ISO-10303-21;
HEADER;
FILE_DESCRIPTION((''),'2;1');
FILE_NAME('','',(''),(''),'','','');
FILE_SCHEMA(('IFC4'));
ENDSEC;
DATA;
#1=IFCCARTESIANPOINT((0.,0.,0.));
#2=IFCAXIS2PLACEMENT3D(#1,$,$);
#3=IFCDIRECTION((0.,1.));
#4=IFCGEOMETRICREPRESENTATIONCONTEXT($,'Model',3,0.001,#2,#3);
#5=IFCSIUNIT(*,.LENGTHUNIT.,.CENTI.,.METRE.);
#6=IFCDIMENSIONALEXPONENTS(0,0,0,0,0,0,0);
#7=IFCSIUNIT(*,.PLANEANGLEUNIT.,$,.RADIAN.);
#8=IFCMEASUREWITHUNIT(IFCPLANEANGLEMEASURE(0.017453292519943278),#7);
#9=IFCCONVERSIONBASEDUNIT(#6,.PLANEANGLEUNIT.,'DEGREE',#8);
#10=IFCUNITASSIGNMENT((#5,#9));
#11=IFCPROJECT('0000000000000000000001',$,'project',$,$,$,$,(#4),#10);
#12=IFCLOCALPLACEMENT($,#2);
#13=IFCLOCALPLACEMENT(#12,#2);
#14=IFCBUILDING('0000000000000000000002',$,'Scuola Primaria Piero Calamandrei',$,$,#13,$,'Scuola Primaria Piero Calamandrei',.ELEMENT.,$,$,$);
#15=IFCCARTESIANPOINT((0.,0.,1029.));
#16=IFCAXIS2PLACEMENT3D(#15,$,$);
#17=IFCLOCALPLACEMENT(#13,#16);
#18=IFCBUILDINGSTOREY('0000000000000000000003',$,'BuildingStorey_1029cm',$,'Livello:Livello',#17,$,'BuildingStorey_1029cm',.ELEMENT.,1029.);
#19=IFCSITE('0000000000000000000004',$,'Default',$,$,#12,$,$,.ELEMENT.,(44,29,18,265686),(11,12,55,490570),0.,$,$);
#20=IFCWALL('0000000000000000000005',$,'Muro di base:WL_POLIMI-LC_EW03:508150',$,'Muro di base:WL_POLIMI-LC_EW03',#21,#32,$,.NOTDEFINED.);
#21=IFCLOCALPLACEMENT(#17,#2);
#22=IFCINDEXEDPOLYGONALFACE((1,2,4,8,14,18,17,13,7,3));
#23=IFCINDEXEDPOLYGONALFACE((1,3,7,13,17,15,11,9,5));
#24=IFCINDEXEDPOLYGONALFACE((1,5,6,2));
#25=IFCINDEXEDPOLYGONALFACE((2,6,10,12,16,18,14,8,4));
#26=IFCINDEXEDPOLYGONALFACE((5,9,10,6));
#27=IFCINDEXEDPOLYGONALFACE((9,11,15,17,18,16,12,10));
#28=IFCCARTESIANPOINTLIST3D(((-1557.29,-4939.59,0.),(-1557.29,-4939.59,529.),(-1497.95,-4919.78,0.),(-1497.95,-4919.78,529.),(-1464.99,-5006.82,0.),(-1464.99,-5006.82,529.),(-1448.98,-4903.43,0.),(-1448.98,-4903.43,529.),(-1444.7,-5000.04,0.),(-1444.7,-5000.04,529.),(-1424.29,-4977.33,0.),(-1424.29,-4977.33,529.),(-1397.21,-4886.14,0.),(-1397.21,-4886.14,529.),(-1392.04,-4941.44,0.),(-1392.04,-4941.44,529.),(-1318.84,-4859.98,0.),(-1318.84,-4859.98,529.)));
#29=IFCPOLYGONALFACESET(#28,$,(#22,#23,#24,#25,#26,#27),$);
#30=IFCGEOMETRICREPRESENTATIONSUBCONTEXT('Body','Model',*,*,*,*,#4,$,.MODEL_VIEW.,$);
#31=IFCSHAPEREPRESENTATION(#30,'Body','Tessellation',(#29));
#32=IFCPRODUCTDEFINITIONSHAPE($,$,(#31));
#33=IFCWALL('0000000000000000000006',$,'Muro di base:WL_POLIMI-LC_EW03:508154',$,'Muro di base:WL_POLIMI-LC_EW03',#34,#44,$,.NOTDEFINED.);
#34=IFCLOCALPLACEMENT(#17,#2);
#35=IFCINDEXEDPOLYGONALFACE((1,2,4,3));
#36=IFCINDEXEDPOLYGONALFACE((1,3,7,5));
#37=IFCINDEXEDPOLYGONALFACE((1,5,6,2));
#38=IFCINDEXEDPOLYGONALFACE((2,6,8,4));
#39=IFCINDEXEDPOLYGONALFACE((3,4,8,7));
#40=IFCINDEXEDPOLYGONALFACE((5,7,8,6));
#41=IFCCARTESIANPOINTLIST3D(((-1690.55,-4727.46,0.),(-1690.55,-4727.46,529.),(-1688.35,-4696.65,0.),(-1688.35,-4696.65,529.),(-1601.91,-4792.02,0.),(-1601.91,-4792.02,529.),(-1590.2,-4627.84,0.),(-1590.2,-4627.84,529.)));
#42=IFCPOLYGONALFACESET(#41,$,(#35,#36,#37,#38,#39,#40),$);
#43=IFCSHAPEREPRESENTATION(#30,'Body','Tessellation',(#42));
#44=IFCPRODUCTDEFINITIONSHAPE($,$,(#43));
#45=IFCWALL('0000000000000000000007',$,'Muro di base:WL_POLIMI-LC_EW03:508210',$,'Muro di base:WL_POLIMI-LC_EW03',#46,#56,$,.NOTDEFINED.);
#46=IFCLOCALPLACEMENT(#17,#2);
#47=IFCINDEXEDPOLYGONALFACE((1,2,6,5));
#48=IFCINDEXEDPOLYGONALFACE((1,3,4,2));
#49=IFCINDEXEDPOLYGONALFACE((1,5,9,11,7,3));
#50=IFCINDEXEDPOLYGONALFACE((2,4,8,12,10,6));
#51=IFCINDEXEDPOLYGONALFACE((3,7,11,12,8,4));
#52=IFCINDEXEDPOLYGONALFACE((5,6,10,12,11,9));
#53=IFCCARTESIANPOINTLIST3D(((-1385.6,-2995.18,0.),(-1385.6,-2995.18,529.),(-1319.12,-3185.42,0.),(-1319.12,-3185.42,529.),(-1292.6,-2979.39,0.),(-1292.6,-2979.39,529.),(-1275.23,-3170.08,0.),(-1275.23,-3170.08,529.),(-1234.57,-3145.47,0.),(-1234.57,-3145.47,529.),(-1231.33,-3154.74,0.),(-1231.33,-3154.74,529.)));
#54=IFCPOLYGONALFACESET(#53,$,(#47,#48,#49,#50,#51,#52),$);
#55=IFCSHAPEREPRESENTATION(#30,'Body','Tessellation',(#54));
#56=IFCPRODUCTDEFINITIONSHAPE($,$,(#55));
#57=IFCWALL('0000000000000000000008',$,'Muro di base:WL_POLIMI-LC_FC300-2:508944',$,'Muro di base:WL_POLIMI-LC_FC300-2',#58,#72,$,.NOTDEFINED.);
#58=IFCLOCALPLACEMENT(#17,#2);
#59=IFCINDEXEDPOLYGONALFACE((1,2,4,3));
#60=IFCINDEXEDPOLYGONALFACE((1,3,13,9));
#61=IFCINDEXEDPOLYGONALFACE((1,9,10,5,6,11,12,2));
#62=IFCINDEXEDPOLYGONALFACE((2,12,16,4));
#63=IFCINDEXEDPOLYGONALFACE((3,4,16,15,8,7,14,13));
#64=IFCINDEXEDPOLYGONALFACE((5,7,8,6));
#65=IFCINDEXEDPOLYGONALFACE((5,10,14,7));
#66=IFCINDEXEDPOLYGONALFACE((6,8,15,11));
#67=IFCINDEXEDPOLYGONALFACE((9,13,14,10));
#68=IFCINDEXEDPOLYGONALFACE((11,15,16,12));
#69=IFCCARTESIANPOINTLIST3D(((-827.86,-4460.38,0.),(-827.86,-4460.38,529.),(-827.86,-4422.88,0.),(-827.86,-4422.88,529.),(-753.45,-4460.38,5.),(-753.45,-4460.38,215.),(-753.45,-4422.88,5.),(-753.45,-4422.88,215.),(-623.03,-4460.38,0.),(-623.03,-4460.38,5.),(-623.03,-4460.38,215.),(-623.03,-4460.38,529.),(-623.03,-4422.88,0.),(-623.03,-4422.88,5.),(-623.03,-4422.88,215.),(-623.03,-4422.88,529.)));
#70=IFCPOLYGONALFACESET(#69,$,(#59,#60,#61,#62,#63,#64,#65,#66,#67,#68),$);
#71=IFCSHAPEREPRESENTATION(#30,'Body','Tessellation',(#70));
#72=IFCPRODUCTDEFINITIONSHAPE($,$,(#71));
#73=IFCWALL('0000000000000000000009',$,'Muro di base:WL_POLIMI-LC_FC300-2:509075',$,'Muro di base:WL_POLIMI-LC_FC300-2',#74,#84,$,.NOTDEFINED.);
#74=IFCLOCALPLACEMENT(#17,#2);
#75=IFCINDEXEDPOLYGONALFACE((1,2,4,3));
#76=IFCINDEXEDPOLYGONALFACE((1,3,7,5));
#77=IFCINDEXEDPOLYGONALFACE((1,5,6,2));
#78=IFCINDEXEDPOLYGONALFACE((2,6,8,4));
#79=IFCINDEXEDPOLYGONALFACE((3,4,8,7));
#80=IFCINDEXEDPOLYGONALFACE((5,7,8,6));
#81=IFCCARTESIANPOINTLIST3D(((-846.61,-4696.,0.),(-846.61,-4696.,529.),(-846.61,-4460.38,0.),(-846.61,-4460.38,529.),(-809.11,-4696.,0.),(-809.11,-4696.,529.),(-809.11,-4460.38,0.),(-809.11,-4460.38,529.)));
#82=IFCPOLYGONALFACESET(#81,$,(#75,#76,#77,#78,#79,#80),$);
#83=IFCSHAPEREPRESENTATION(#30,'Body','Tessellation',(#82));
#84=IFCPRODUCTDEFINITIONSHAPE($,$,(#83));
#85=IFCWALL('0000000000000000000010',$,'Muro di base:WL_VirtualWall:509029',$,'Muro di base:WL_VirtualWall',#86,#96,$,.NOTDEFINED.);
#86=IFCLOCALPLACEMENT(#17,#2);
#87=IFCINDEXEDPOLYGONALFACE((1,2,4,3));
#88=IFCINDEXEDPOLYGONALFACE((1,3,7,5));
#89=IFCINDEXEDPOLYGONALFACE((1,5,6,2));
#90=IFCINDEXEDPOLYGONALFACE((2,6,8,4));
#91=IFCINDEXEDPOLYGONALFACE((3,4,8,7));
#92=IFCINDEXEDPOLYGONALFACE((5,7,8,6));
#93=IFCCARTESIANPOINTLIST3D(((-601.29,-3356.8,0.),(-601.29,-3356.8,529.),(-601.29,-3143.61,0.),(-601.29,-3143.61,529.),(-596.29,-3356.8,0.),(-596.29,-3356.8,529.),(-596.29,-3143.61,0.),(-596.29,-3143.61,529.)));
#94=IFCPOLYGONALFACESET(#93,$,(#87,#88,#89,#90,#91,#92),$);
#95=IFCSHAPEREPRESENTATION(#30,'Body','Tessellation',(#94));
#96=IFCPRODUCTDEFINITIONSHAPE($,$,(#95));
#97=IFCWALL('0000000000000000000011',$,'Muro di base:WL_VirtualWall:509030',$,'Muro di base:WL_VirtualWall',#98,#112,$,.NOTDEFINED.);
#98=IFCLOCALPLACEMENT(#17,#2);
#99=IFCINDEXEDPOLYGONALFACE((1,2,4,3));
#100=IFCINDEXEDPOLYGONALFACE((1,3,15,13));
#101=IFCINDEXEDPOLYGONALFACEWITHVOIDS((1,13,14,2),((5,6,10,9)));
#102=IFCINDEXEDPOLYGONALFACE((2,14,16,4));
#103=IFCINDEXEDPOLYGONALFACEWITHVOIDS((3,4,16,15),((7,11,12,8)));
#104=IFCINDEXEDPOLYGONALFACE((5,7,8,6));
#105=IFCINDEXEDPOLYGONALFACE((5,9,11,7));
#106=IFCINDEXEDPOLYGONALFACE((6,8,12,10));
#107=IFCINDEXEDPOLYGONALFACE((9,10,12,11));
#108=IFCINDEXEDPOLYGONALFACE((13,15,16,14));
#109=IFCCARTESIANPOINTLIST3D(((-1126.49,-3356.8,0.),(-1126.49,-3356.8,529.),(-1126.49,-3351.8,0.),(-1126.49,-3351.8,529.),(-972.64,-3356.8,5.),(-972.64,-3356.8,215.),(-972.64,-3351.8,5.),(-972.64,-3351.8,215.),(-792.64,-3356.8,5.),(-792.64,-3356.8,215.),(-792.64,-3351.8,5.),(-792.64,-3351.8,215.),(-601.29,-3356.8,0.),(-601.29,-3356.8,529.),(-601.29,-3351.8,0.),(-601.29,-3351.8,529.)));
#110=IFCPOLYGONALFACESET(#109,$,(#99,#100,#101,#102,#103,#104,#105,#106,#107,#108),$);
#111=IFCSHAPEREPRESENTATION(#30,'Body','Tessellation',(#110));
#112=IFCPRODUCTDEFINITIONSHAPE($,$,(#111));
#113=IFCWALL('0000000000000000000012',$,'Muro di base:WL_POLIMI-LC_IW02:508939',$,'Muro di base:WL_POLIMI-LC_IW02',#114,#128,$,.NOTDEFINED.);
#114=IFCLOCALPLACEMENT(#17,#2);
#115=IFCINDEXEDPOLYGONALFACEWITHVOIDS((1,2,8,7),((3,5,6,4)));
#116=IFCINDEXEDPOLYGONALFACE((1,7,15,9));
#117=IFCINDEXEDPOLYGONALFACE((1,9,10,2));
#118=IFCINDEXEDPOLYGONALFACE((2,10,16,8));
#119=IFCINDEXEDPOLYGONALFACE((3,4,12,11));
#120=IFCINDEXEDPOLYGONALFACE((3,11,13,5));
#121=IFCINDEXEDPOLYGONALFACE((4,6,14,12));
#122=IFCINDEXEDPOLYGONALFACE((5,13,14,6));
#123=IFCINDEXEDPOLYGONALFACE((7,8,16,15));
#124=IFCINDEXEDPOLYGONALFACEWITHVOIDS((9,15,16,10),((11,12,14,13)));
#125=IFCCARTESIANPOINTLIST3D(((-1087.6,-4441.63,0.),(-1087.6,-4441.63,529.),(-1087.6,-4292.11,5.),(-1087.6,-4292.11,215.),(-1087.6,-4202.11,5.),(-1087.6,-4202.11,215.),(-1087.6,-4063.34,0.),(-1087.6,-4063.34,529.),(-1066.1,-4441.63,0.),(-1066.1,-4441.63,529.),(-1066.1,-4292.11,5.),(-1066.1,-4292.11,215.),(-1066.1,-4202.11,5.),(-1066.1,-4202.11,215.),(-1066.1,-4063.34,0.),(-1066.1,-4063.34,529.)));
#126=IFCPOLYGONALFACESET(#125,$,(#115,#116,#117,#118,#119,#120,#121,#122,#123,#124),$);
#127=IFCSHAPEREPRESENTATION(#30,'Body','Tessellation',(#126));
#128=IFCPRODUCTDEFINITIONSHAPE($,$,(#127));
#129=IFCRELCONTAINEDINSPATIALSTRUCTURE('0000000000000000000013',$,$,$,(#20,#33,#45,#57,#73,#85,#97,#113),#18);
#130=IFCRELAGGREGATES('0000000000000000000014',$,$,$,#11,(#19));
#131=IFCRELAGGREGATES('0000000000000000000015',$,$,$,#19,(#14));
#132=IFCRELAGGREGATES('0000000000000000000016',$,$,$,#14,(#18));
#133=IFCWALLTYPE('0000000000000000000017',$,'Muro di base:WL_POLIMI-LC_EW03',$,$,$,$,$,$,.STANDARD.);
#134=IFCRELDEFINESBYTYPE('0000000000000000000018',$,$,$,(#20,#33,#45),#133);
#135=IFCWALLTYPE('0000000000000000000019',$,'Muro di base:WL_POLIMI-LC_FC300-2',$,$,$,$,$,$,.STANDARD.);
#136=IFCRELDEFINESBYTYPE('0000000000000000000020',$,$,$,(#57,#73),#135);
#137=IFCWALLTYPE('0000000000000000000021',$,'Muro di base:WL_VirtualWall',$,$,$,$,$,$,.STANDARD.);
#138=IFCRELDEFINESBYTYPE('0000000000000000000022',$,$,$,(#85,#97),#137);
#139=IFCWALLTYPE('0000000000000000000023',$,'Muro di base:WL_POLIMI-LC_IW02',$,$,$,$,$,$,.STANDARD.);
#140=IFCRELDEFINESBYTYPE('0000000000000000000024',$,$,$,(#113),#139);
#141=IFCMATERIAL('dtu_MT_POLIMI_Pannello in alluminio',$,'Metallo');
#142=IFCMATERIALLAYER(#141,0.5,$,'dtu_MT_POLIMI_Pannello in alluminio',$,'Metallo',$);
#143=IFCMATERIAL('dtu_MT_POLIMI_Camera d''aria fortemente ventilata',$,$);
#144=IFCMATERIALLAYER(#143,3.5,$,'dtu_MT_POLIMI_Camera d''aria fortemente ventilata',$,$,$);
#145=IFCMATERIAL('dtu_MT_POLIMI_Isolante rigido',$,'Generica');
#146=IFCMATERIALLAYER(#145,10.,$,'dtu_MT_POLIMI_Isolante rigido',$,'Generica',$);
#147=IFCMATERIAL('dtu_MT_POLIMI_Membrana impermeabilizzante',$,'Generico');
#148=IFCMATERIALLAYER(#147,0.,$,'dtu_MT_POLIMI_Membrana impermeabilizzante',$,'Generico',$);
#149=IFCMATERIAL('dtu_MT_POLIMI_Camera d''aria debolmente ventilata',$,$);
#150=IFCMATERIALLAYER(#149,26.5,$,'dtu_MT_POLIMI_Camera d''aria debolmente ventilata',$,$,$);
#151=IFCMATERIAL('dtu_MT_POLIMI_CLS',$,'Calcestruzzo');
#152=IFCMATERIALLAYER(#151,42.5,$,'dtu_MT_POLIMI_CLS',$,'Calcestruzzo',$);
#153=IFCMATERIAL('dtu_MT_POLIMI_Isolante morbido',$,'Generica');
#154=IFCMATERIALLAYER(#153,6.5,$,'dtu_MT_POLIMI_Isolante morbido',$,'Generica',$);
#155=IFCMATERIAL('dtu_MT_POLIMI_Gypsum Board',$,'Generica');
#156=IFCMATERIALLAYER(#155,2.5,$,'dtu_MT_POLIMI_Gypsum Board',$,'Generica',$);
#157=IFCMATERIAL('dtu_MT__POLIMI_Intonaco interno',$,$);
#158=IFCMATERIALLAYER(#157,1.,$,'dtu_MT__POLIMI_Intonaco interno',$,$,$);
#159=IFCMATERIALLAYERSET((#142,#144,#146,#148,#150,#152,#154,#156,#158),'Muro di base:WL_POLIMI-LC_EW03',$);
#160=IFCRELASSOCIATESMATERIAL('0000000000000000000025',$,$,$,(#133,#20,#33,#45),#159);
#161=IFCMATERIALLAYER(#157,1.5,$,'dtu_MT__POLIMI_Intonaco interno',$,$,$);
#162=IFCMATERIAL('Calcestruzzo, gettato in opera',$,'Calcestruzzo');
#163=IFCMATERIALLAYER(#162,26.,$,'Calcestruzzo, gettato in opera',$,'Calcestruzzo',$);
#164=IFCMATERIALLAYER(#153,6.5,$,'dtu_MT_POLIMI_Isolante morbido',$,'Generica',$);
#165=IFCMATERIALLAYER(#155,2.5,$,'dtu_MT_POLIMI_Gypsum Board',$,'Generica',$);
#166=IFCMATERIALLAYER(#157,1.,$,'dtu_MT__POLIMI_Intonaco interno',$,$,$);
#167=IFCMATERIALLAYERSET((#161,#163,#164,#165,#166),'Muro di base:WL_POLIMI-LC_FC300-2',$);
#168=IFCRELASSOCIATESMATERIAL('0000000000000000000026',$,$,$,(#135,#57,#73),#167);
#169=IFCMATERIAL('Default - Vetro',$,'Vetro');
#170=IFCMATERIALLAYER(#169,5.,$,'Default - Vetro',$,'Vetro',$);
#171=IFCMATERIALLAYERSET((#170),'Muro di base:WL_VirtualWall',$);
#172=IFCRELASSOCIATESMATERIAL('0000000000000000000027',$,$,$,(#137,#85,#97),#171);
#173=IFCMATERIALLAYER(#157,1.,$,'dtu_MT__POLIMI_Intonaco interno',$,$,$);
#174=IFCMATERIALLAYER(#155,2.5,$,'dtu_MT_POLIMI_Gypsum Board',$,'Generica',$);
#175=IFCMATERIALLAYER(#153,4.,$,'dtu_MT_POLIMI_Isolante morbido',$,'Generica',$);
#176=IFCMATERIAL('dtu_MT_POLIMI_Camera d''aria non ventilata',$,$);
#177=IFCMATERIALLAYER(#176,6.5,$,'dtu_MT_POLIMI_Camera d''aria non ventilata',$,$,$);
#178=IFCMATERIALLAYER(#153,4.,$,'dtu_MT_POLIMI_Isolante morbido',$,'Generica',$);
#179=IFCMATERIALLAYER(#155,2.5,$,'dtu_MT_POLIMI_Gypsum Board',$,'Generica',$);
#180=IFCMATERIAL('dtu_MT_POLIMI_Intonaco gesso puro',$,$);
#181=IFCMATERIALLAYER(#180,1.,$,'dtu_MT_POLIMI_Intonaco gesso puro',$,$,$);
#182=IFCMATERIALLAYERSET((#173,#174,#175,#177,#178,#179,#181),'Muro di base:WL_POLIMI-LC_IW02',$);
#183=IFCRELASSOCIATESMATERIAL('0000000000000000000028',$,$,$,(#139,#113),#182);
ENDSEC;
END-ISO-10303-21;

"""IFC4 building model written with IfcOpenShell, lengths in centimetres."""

from ifc_helpers import new_model, entity, si_unit, converted_unit, direction, frame, frame_2d, origin, place, context, subcontext, project, spatial, polyline, rectangle, outline, extrude, material, layer, layer_set, layer_usage, type_object, element, save


model = new_model("IFC4")

# Units and contexts
model_context = context("Model", 3, precision=0.001, world=origin(), true_north=direction((0.0, 1.0)))
body_context = subcontext(model_context, "Body", "Model", "MODEL_VIEW")
ifc_project = project(units=[si_unit("LENGTHUNIT", "METRE", prefix="CENTI"), converted_unit("PLANEANGLEUNIT", "DEGREE", entity("IfcPlaneAngleMeasure", 0.017453292519943278), si_unit("PLANEANGLEUNIT", "RADIAN"), dimensions=[0, 0, 0, 0, 0, 0, 0])], contexts=[model_context])

# Site, building, storey
site_placement = place(None, origin())
site = spatial("IfcSite", under=ifc_project, at=site_placement, Name="Default", CompositionType="ELEMENT", RefLatitude=(44, 29, 18, 265686), RefLongitude=(11, 12, 55, 490570), RefElevation=0.0)
building_placement = place(site_placement, origin())
building = spatial("IfcBuilding", under=site, at=building_placement, Name="Scuola Primaria Piero Calamandrei", LongName="Scuola Primaria Piero Calamandrei", CompositionType="ELEMENT")
storey_placement = place(building_placement, frame((0.0, 0.0, 1029.0)))
storey = spatial("IfcBuildingStorey", under=building, at=storey_placement, Name="BuildingStorey_1029cm", ObjectType="Livello:Livello", LongName="BuildingStorey_1029cm", CompositionType="ELEMENT", Elevation=1029.0)

# Shared definitions
ifc_material_1 = material(Name="Default - Vetro", Category="Vetro")
ifc_material_2 = material(Name="dtu_MT_POLIMI_Pannello in alluminio", Category="Metallo")
ifc_material_3 = material(Name="dtu_MT_POLIMI_Camera d'aria fortemente ventilata")
ifc_material_4 = material(Name="dtu_MT_POLIMI_Isolante rigido", Category="Generica")
ifc_material_5 = material(Name="dtu_MT_POLIMI_Membrana impermeabilizzante", Category="Generico")
ifc_material_6 = material(Name="dtu_MT_POLIMI_Camera d'aria debolmente ventilata")
ifc_material_7 = material(Name="dtu_MT_POLIMI_Isolante morbido", Category="Generica")
ifc_material_8 = material(Name="dtu_MT_POLIMI_Gypsum Board", Category="Generica")
ifc_material_9 = material(Name="dtu_MT__POLIMI_Intonaco interno")

# Shared definitions
ifc_layer_1 = layer(ifc_material_2, 0.5, Name="dtu_MT_POLIMI_Pannello in alluminio", Category="Metallo")
ifc_layer_2 = layer(ifc_material_3, 3.5, Name="dtu_MT_POLIMI_Camera d'aria fortemente ventilata")
ifc_layer_3 = layer(ifc_material_4, 10.0, Name="dtu_MT_POLIMI_Isolante rigido", Category="Generica")
ifc_layer_4 = layer(ifc_material_5, 0.0, Name="dtu_MT_POLIMI_Membrana impermeabilizzante", Category="Generico")
ifc_layer_5 = layer(ifc_material_6, 26.5, Name="dtu_MT_POLIMI_Camera d'aria debolmente ventilata")
ifc_material_10 = material(Name="dtu_MT_POLIMI_CLS", Category="Calcestruzzo")
ifc_layer_6 = layer(ifc_material_10, 42.5, Name="dtu_MT_POLIMI_CLS", Category="Calcestruzzo")
ifc_layer_7 = layer(ifc_material_7, 6.5, Name="dtu_MT_POLIMI_Isolante morbido", Category="Generica")
ifc_layer_8 = layer(ifc_material_8, 2.5, Name="dtu_MT_POLIMI_Gypsum Board", Category="Generica")
ifc_layer_9 = layer(ifc_material_9, 1.0, Name="dtu_MT__POLIMI_Intonaco interno")
ifc_layer_set_1 = layer_set([ifc_layer_1, ifc_layer_2, ifc_layer_3, ifc_layer_4, ifc_layer_5, ifc_layer_6, ifc_layer_7, ifc_layer_8, ifc_layer_9], Name="Muro di base:WL_POLIMI-LC_EW03")
wall_type_1 = type_object("IfcWallType", Name="Muro di base:WL_POLIMI-LC_EW03", PredefinedType="STANDARD", material=ifc_layer_set_1)

# Walls
ifc_layer_usage_1 = layer_usage(ifc_layer_set_1, "AXIS2", "NEGATIVE", 46.5)
wall_1_placement = place(storey_placement, frame((-1304.11, -4904.08, 0.0), z_axis=(0.0, 0.0, 1.0), x_axis=(-0.948531, -0.316683, 0.0)))
element("IfcWall", 1, at=wall_1_placement, inside=storey, type_object=wall_type_1, material=ifc_layer_usage_1, Name="Muro di base:WL_POLIMI-LC_EW03:508150", ObjectType="Muro di base:WL_POLIMI-LC_EW03", PredefinedType="NOTDEFINED", context=body_context, shape_type="SweptSolid", body=[
    extrude(outline(polyline([(251.39, -46.5), (185.13, 46.5), (163.74, 46.5), (137.19, 31.42), (95.23, 7.59), (0.0, -46.5), (82.62, -46.5), (137.2, -46.5), (188.83, -46.5), (251.39, -46.5)])), origin(), (0.0, 0.0, 1.0), 529.0),
])
ifc_layer_usage_2 = layer_usage(ifc_layer_set_1, "AXIS2", "NEGATIVE", 46.5)
wall_2_placement = place(storey_placement, frame((-1648.3, -4788.72, 0.0), z_axis=(0.0, 0.0, 1.0), x_axis=(0.071134, 0.997467, 0.0)))
element("IfcWall", 2, at=wall_2_placement, inside=storey, type_object=wall_type_1, material=ifc_layer_usage_2, Name="Muro di base:WL_POLIMI-LC_EW03:508154", ObjectType="Muro di base:WL_POLIMI-LC_EW03", PredefinedType="NOTDEFINED", context=body_context, shape_type="SweptSolid", body=[
    extrude(outline(polyline([(164.6, -46.5), (88.99, 46.5), (58.09, 46.5), (0.0, -46.5), (164.6, -46.5)])), origin(), (0.0, 0.0, 1.0), 529.0),
])
ifc_layer_usage_3 = layer_usage(ifc_layer_set_1, "AXIS2", "NEGATIVE", 46.5)
wall_3_placement = place(storey_placement, frame((-1275.23, -3170.08, 0.0), z_axis=(0.0, 0.0, 1.0), x_axis=(-0.32988, 0.944023, 0.0)))
element("IfcWall", 3, at=wall_3_placement, inside=storey, type_object=wall_type_1, material=ifc_layer_usage_3, Name="Muro di base:WL_POLIMI-LC_EW03:508210", ObjectType="Muro di base:WL_POLIMI-LC_EW03", PredefinedType="NOTDEFINED", context=body_context, shape_type="SweptSolid", body=[
    extrude(outline(polyline([(185.74, -46.5), (201.52, 46.5), (0.0, 46.5), (0.0, 0.0), (0.0, -46.5), (9.82, -46.5), (185.74, -46.5)])), origin(), (0.0, 0.0, 1.0), 529.0),
])
ifc_layer_10 = layer(ifc_material_9, 1.5, Name="dtu_MT__POLIMI_Intonaco interno")
ifc_material_11 = material(Name="Calcestruzzo, gettato in opera", Category="Calcestruzzo")
ifc_layer_11 = layer(ifc_material_11, 26.0, Name="Calcestruzzo, gettato in opera", Category="Calcestruzzo")
ifc_layer_12 = layer(ifc_material_7, 6.5, Name="dtu_MT_POLIMI_Isolante morbido", Category="Generica")
ifc_layer_13 = layer(ifc_material_8, 2.5, Name="dtu_MT_POLIMI_Gypsum Board", Category="Generica")
ifc_layer_14 = layer(ifc_material_9, 1.0, Name="dtu_MT__POLIMI_Intonaco interno")
ifc_layer_set_2 = layer_set([ifc_layer_10, ifc_layer_11, ifc_layer_12, ifc_layer_13, ifc_layer_14], Name="Muro di base:WL_POLIMI-LC_FC300-2")
wall_type_2 = type_object("IfcWallType", Name="Muro di base:WL_POLIMI-LC_FC300-2", PredefinedType="STANDARD", material=ifc_layer_set_2)

# Wall, opening
ifc_layer_usage_4 = layer_usage(ifc_layer_set_2, "AXIS2", "NEGATIVE", 18.75)
wall_4_placement = place(storey_placement, frame((-623.03, -4441.63, 0.0), z_axis=(0.0, 0.0, 1.0), x_axis=(-1.0, 0.0, 0.0)))
wall_4 = element("IfcWall", 4, at=wall_4_placement, inside=storey, type_object=wall_type_2, material=ifc_layer_usage_4, Name="Muro di base:WL_POLIMI-LC_FC300-2:508944", ObjectType="Muro di base:WL_POLIMI-LC_FC300-2", PredefinedType="NOTDEFINED", context=body_context, shape_type="SweptSolid", body=[
    extrude(rectangle(XDim=204.83, YDim=37.5, at=frame_2d((102.41, 0.0), x_axis=(-1.0, 0.0))), origin(), (0.0, 0.0, 1.0), 529.0),
])
opening_1_placement = place(wall_4_placement, frame((-9.59, -18.75, 5.0)))
element("IfcOpeningElement", 5, at=opening_1_placement, cuts=wall_4, PredefinedType="OPENING", context=body_context, shape_type="SweptSolid", body=[
    extrude(rectangle(XDim=210.0, YDim=140.0, at=frame_2d((105.0, 70.0), x_axis=(1.0, 0.0))), frame((0.0, 0.0, 0.0), z_axis=(0.0, 1.0, 0.0), x_axis=(0.0, 0.0, 1.0)), (0.0, 0.0, 1.0), 37.5),
])

# Walls
ifc_layer_usage_5 = layer_usage(ifc_layer_set_2, "AXIS2", "NEGATIVE", 18.75)
wall_5_placement = place(storey_placement, frame((-827.86, -4460.38, 0.0), z_axis=(0.0, 0.0, 1.0), x_axis=(0.0, -1.0, 0.0)))
element("IfcWall", 6, at=wall_5_placement, inside=storey, type_object=wall_type_2, material=ifc_layer_usage_5, Name="Muro di base:WL_POLIMI-LC_FC300-2:509075", ObjectType="Muro di base:WL_POLIMI-LC_FC300-2", PredefinedType="NOTDEFINED", context=body_context, shape_type="SweptSolid", body=[
    extrude(rectangle(XDim=235.61, YDim=37.5, at=frame_2d((117.81, 0.0), x_axis=(-1.0, 0.0))), origin(), (0.0, 0.0, 1.0), 529.0),
])
ifc_layer_15 = layer(ifc_material_1, 5.0, Name="Default - Vetro", Category="Vetro")
ifc_layer_set_3 = layer_set([ifc_layer_15], Name="Muro di base:WL_VirtualWall")
ifc_layer_usage_6 = layer_usage(ifc_layer_set_3, "AXIS2", "NEGATIVE", 2.5)
wall_type_3 = type_object("IfcWallType", Name="Muro di base:WL_VirtualWall", PredefinedType="STANDARD", material=ifc_layer_set_3)
wall_6_placement = place(storey_placement, frame((-598.79, -3356.8, 0.0), z_axis=(0.0, 0.0, 1.0), x_axis=(0.0, 1.0, 0.0)))
element("IfcWall", 7, at=wall_6_placement, inside=storey, type_object=wall_type_3, material=ifc_layer_usage_6, Name="Muro di base:WL_VirtualWall:509029", ObjectType="Muro di base:WL_VirtualWall", PredefinedType="NOTDEFINED", context=body_context, shape_type="SweptSolid", body=[
    extrude(rectangle(XDim=213.19, YDim=5.0, at=frame_2d((106.59, 0.0), x_axis=(-1.0, 0.0))), origin(), (0.0, 0.0, 1.0), 529.0),
])

# Wall, opening
ifc_layer_usage_7 = layer_usage(ifc_layer_set_3, "AXIS2", "NEGATIVE", 2.5)
wall_7_placement = place(storey_placement, frame((-1126.49, -3354.3, 0.0)))
wall_7 = element("IfcWall", 8, at=wall_7_placement, inside=storey, type_object=wall_type_3, material=ifc_layer_usage_7, Name="Muro di base:WL_VirtualWall:509030", ObjectType="Muro di base:WL_VirtualWall", PredefinedType="NOTDEFINED", context=body_context, shape_type="SweptSolid", body=[
    extrude(rectangle(XDim=525.2, YDim=5.0, at=frame_2d((262.6, 0.0), x_axis=(-1.0, 0.0))), origin(), (0.0, 0.0, 1.0), 529.0),
])
opening_2_placement = place(wall_7_placement, frame((153.85, -2.5, 5.0)))
element("IfcOpeningElement", 9, at=opening_2_placement, cuts=wall_7, PredefinedType="OPENING", context=body_context, shape_type="SweptSolid", body=[
    extrude(rectangle(XDim=210.0, YDim=180.0, at=frame_2d((105.0, 90.0), x_axis=(1.0, 0.0))), frame((0.0, 0.0, 0.0), z_axis=(0.0, 1.0, 0.0), x_axis=(0.0, 0.0, 1.0)), (0.0, 0.0, 1.0), 5.0),
])

# Shared definitions
ifc_layer_16 = layer(ifc_material_9, 1.0, Name="dtu_MT__POLIMI_Intonaco interno")
ifc_layer_17 = layer(ifc_material_8, 2.5, Name="dtu_MT_POLIMI_Gypsum Board", Category="Generica")
ifc_layer_18 = layer(ifc_material_7, 4.0, Name="dtu_MT_POLIMI_Isolante morbido", Category="Generica")
ifc_material_12 = material(Name="dtu_MT_POLIMI_Camera d'aria non ventilata")
ifc_layer_19 = layer(ifc_material_12, 6.5, Name="dtu_MT_POLIMI_Camera d'aria non ventilata")
ifc_layer_20 = layer(ifc_material_7, 4.0, Name="dtu_MT_POLIMI_Isolante morbido", Category="Generica")
ifc_layer_21 = layer(ifc_material_8, 2.5, Name="dtu_MT_POLIMI_Gypsum Board", Category="Generica")
ifc_material_13 = material(Name="dtu_MT_POLIMI_Intonaco gesso puro")
ifc_layer_22 = layer(ifc_material_13, 1.0, Name="dtu_MT_POLIMI_Intonaco gesso puro")
ifc_layer_set_4 = layer_set([ifc_layer_16, ifc_layer_17, ifc_layer_18, ifc_layer_19, ifc_layer_20, ifc_layer_21, ifc_layer_22], Name="Muro di base:WL_POLIMI-LC_IW02")
wall_type_4 = type_object("IfcWallType", Name="Muro di base:WL_POLIMI-LC_IW02", PredefinedType="STANDARD", material=ifc_layer_set_4)

# Wall, opening
ifc_layer_usage_8 = layer_usage(ifc_layer_set_4, "AXIS2", "NEGATIVE", 10.75)
wall_8_placement = place(storey_placement, frame((-1076.85, -4063.34, 0.0), z_axis=(0.0, 0.0, 1.0), x_axis=(0.0, -1.0, 0.0)))
wall_8 = element("IfcWall", 10, at=wall_8_placement, inside=storey, type_object=wall_type_4, material=ifc_layer_usage_8, Name="Muro di base:WL_POLIMI-LC_IW02:508939", ObjectType="Muro di base:WL_POLIMI-LC_IW02", PredefinedType="NOTDEFINED", context=body_context, shape_type="SweptSolid", body=[
    extrude(rectangle(XDim=378.3, YDim=21.5, at=frame_2d((189.15, 0.0), x_axis=(-1.0, 0.0))), origin(), (0.0, 0.0, 1.0), 529.0),
])
opening_3_placement = place(wall_8_placement, frame((228.77, 10.75, 5.0)))
element("IfcOpeningElement", 11, at=opening_3_placement, cuts=wall_8, PredefinedType="OPENING", context=body_context, shape_type="SweptSolid", body=[
    extrude(rectangle(XDim=210.0, YDim=90.0, at=frame_2d((105.0, 45.0), x_axis=(1.0, 0.0))), frame((0.0, 0.0, 0.0), z_axis=(0.0, -1.0, 0.0), x_axis=(0.0, 0.0, 1.0)), (0.0, 0.0, 1.0), 21.5),
])

save(model, "model.ifc")
